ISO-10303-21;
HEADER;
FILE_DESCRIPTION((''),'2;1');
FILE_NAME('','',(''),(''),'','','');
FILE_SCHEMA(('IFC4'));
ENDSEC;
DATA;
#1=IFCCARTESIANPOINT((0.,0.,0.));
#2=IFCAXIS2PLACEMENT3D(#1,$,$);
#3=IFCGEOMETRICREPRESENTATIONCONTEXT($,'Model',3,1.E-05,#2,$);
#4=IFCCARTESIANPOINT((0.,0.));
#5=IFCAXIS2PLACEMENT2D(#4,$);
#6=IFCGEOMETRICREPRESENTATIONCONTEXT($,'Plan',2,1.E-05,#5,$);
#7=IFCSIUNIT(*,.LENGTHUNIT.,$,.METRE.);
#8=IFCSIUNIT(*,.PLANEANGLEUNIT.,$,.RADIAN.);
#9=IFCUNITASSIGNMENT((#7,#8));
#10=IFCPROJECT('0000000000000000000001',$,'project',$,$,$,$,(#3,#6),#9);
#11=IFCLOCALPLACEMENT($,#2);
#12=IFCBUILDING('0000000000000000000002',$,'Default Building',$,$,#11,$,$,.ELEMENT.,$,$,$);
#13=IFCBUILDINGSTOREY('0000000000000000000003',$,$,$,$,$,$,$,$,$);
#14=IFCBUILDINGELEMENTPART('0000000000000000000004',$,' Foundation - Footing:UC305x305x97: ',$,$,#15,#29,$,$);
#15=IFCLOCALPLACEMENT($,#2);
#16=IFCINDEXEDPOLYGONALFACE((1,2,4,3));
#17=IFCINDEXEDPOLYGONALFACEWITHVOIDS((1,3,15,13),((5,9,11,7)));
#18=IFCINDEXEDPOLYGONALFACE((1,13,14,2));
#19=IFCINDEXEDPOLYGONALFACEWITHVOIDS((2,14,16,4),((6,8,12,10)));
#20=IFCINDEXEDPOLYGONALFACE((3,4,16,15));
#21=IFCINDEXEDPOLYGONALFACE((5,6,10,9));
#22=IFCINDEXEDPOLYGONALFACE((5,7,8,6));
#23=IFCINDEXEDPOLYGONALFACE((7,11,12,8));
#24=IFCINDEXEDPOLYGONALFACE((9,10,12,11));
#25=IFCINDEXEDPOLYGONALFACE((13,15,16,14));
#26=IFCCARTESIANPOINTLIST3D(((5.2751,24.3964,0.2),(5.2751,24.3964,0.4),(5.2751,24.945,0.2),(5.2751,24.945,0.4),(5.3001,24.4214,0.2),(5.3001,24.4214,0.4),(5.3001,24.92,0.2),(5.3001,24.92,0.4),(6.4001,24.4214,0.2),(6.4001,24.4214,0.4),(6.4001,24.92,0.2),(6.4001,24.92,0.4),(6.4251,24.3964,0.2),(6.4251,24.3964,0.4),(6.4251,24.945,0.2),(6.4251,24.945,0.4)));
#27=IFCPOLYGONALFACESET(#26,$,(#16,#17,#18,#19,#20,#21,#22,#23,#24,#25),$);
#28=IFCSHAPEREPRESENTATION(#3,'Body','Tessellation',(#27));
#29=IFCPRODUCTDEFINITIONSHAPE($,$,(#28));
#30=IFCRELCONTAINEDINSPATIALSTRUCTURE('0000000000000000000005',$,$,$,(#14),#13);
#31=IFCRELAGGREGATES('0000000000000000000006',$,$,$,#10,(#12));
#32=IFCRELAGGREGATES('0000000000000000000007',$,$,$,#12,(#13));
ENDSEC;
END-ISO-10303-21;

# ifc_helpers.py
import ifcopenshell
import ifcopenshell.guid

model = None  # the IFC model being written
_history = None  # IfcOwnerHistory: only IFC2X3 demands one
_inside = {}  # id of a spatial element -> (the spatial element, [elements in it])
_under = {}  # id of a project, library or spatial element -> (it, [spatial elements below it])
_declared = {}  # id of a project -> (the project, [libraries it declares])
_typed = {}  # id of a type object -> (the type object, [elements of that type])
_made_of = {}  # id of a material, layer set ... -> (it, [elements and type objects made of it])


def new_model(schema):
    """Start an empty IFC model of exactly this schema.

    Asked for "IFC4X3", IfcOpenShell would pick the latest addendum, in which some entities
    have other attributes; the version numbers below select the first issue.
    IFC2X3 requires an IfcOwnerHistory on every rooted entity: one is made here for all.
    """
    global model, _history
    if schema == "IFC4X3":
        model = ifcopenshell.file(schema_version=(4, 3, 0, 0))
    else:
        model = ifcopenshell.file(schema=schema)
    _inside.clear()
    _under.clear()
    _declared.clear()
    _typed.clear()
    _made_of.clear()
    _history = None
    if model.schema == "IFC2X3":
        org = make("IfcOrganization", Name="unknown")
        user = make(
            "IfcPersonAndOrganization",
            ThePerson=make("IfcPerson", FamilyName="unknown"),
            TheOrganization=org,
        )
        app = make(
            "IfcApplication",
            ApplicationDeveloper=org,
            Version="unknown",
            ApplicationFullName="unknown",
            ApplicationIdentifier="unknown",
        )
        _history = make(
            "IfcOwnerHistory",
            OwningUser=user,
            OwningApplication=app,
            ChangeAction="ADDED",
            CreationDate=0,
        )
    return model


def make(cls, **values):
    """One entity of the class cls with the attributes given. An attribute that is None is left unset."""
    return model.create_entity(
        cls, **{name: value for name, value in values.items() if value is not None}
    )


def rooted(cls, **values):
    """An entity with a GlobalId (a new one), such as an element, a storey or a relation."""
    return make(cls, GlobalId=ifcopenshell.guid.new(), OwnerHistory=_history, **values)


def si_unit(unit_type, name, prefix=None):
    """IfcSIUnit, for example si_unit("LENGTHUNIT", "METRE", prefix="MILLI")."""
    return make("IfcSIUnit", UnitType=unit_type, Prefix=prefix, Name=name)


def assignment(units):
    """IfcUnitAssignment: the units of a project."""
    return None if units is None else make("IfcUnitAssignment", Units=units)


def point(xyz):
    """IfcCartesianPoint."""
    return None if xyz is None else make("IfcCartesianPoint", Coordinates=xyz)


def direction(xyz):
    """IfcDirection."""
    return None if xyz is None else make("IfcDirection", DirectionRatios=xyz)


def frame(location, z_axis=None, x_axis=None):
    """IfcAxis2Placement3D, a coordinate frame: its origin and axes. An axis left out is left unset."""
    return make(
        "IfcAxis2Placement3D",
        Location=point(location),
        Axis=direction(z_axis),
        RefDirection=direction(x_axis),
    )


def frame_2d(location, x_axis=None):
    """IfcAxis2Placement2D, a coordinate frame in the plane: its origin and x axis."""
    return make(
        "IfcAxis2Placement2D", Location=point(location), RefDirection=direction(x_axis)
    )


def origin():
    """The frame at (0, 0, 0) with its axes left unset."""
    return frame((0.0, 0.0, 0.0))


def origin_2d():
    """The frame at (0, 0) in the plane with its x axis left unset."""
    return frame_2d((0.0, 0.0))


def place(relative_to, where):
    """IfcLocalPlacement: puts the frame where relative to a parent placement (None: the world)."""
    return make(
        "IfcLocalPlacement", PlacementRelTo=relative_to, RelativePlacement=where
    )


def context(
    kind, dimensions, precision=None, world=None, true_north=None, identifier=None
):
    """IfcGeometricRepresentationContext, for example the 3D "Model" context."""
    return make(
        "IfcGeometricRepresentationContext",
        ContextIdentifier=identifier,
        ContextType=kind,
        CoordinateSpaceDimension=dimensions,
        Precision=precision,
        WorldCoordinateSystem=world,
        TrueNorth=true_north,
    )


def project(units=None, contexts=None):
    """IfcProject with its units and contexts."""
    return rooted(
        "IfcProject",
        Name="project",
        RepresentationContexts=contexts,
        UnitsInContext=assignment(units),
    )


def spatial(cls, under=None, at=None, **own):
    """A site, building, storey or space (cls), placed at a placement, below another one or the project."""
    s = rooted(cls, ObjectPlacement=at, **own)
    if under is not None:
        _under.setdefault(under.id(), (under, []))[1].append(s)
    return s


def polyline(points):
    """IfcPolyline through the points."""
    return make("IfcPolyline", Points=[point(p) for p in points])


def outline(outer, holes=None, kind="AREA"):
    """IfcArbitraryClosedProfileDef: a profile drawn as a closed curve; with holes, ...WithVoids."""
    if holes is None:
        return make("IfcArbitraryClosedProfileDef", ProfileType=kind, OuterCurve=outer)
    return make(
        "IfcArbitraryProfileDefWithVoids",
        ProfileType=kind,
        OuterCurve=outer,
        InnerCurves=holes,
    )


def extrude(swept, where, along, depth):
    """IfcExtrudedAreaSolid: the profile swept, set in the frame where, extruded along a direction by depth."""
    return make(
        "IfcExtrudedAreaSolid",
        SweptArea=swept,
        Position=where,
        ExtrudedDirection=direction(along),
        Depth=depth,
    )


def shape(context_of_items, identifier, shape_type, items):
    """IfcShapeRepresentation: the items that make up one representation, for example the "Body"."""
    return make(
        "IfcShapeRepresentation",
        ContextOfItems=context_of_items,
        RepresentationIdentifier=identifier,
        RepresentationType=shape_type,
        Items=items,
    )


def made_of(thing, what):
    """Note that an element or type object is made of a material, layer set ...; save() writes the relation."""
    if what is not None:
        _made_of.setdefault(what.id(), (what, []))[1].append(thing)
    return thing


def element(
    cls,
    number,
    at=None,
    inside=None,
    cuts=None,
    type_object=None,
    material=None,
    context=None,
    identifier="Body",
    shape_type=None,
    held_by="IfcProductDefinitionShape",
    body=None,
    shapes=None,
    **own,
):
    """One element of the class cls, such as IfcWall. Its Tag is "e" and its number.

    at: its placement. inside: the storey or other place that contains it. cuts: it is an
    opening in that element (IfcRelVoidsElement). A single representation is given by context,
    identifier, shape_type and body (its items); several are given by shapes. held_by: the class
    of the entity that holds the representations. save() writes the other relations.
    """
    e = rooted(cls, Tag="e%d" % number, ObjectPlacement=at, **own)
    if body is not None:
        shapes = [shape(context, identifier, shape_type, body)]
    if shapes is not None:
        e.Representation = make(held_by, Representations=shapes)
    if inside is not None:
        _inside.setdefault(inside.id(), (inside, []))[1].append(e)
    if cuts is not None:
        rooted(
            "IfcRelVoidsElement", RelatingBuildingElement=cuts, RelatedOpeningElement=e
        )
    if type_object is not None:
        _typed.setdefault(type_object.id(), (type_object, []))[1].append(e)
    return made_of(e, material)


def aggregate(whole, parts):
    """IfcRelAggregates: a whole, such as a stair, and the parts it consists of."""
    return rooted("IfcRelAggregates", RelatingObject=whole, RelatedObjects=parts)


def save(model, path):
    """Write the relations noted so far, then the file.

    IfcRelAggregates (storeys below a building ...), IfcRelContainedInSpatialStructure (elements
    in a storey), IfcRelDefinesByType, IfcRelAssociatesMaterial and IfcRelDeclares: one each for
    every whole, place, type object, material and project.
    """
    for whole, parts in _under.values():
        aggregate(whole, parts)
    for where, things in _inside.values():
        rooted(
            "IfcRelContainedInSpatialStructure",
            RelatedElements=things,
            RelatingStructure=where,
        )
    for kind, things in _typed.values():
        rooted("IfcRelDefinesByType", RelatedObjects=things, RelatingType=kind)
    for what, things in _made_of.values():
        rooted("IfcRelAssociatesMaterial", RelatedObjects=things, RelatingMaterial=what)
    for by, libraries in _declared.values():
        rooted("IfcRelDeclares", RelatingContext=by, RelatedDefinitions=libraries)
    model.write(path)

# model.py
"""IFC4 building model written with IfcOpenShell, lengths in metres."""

from ifc_helpers import new_model, si_unit, origin, origin_2d, place, context, project, spatial, polyline, outline, extrude, element, save


model = new_model("IFC4")

# Units and contexts
model_context = context("Model", 3, precision=1e-05, world=origin())
plan_context = context("Plan", 2, precision=1e-05, world=origin_2d())
ifc_project = project(units=[si_unit("LENGTHUNIT", "METRE"), si_unit("PLANEANGLEUNIT", "RADIAN")], contexts=[model_context, plan_context])

# Building, storey
building_placement = place(None, origin())
building = spatial("IfcBuilding", under=ifc_project, at=building_placement, Name="Default Building", CompositionType="ELEMENT")
storey = spatial("IfcBuildingStorey", under=building)

# Building element part, opening
building_element_part_1 = element("IfcBuildingElementPart", 1, inside=storey, Name=" Foundation - Footing:UC305x305x97: ", context=model_context, shape_type="SweptSolid", body=[
    extrude(outline(polyline([(5.2751, 24.3964, 0.2), (6.4251, 24.3964, 0.2), (6.4251, 24.945, 0.2), (5.2751, 24.945, 0.2), (5.2751, 24.3964, 0.2)])), None, (0.0, 0.0, 1.0), 0.2),
])
element("IfcOpeningElement", 2, inside=storey, cuts=building_element_part_1, context=model_context, shape_type="SweptSolid", body=[
    extrude(outline(polyline([(5.3001, 24.4214, 0.2), (6.4001, 24.4214, 0.2), (6.4001, 24.92, 0.2), (5.3001, 24.92, 0.2), (5.3001, 24.4214, 0.2)])), None, (0.0, 0.0, 1.0), 0.2),
])

save(model, "model.ifc")
